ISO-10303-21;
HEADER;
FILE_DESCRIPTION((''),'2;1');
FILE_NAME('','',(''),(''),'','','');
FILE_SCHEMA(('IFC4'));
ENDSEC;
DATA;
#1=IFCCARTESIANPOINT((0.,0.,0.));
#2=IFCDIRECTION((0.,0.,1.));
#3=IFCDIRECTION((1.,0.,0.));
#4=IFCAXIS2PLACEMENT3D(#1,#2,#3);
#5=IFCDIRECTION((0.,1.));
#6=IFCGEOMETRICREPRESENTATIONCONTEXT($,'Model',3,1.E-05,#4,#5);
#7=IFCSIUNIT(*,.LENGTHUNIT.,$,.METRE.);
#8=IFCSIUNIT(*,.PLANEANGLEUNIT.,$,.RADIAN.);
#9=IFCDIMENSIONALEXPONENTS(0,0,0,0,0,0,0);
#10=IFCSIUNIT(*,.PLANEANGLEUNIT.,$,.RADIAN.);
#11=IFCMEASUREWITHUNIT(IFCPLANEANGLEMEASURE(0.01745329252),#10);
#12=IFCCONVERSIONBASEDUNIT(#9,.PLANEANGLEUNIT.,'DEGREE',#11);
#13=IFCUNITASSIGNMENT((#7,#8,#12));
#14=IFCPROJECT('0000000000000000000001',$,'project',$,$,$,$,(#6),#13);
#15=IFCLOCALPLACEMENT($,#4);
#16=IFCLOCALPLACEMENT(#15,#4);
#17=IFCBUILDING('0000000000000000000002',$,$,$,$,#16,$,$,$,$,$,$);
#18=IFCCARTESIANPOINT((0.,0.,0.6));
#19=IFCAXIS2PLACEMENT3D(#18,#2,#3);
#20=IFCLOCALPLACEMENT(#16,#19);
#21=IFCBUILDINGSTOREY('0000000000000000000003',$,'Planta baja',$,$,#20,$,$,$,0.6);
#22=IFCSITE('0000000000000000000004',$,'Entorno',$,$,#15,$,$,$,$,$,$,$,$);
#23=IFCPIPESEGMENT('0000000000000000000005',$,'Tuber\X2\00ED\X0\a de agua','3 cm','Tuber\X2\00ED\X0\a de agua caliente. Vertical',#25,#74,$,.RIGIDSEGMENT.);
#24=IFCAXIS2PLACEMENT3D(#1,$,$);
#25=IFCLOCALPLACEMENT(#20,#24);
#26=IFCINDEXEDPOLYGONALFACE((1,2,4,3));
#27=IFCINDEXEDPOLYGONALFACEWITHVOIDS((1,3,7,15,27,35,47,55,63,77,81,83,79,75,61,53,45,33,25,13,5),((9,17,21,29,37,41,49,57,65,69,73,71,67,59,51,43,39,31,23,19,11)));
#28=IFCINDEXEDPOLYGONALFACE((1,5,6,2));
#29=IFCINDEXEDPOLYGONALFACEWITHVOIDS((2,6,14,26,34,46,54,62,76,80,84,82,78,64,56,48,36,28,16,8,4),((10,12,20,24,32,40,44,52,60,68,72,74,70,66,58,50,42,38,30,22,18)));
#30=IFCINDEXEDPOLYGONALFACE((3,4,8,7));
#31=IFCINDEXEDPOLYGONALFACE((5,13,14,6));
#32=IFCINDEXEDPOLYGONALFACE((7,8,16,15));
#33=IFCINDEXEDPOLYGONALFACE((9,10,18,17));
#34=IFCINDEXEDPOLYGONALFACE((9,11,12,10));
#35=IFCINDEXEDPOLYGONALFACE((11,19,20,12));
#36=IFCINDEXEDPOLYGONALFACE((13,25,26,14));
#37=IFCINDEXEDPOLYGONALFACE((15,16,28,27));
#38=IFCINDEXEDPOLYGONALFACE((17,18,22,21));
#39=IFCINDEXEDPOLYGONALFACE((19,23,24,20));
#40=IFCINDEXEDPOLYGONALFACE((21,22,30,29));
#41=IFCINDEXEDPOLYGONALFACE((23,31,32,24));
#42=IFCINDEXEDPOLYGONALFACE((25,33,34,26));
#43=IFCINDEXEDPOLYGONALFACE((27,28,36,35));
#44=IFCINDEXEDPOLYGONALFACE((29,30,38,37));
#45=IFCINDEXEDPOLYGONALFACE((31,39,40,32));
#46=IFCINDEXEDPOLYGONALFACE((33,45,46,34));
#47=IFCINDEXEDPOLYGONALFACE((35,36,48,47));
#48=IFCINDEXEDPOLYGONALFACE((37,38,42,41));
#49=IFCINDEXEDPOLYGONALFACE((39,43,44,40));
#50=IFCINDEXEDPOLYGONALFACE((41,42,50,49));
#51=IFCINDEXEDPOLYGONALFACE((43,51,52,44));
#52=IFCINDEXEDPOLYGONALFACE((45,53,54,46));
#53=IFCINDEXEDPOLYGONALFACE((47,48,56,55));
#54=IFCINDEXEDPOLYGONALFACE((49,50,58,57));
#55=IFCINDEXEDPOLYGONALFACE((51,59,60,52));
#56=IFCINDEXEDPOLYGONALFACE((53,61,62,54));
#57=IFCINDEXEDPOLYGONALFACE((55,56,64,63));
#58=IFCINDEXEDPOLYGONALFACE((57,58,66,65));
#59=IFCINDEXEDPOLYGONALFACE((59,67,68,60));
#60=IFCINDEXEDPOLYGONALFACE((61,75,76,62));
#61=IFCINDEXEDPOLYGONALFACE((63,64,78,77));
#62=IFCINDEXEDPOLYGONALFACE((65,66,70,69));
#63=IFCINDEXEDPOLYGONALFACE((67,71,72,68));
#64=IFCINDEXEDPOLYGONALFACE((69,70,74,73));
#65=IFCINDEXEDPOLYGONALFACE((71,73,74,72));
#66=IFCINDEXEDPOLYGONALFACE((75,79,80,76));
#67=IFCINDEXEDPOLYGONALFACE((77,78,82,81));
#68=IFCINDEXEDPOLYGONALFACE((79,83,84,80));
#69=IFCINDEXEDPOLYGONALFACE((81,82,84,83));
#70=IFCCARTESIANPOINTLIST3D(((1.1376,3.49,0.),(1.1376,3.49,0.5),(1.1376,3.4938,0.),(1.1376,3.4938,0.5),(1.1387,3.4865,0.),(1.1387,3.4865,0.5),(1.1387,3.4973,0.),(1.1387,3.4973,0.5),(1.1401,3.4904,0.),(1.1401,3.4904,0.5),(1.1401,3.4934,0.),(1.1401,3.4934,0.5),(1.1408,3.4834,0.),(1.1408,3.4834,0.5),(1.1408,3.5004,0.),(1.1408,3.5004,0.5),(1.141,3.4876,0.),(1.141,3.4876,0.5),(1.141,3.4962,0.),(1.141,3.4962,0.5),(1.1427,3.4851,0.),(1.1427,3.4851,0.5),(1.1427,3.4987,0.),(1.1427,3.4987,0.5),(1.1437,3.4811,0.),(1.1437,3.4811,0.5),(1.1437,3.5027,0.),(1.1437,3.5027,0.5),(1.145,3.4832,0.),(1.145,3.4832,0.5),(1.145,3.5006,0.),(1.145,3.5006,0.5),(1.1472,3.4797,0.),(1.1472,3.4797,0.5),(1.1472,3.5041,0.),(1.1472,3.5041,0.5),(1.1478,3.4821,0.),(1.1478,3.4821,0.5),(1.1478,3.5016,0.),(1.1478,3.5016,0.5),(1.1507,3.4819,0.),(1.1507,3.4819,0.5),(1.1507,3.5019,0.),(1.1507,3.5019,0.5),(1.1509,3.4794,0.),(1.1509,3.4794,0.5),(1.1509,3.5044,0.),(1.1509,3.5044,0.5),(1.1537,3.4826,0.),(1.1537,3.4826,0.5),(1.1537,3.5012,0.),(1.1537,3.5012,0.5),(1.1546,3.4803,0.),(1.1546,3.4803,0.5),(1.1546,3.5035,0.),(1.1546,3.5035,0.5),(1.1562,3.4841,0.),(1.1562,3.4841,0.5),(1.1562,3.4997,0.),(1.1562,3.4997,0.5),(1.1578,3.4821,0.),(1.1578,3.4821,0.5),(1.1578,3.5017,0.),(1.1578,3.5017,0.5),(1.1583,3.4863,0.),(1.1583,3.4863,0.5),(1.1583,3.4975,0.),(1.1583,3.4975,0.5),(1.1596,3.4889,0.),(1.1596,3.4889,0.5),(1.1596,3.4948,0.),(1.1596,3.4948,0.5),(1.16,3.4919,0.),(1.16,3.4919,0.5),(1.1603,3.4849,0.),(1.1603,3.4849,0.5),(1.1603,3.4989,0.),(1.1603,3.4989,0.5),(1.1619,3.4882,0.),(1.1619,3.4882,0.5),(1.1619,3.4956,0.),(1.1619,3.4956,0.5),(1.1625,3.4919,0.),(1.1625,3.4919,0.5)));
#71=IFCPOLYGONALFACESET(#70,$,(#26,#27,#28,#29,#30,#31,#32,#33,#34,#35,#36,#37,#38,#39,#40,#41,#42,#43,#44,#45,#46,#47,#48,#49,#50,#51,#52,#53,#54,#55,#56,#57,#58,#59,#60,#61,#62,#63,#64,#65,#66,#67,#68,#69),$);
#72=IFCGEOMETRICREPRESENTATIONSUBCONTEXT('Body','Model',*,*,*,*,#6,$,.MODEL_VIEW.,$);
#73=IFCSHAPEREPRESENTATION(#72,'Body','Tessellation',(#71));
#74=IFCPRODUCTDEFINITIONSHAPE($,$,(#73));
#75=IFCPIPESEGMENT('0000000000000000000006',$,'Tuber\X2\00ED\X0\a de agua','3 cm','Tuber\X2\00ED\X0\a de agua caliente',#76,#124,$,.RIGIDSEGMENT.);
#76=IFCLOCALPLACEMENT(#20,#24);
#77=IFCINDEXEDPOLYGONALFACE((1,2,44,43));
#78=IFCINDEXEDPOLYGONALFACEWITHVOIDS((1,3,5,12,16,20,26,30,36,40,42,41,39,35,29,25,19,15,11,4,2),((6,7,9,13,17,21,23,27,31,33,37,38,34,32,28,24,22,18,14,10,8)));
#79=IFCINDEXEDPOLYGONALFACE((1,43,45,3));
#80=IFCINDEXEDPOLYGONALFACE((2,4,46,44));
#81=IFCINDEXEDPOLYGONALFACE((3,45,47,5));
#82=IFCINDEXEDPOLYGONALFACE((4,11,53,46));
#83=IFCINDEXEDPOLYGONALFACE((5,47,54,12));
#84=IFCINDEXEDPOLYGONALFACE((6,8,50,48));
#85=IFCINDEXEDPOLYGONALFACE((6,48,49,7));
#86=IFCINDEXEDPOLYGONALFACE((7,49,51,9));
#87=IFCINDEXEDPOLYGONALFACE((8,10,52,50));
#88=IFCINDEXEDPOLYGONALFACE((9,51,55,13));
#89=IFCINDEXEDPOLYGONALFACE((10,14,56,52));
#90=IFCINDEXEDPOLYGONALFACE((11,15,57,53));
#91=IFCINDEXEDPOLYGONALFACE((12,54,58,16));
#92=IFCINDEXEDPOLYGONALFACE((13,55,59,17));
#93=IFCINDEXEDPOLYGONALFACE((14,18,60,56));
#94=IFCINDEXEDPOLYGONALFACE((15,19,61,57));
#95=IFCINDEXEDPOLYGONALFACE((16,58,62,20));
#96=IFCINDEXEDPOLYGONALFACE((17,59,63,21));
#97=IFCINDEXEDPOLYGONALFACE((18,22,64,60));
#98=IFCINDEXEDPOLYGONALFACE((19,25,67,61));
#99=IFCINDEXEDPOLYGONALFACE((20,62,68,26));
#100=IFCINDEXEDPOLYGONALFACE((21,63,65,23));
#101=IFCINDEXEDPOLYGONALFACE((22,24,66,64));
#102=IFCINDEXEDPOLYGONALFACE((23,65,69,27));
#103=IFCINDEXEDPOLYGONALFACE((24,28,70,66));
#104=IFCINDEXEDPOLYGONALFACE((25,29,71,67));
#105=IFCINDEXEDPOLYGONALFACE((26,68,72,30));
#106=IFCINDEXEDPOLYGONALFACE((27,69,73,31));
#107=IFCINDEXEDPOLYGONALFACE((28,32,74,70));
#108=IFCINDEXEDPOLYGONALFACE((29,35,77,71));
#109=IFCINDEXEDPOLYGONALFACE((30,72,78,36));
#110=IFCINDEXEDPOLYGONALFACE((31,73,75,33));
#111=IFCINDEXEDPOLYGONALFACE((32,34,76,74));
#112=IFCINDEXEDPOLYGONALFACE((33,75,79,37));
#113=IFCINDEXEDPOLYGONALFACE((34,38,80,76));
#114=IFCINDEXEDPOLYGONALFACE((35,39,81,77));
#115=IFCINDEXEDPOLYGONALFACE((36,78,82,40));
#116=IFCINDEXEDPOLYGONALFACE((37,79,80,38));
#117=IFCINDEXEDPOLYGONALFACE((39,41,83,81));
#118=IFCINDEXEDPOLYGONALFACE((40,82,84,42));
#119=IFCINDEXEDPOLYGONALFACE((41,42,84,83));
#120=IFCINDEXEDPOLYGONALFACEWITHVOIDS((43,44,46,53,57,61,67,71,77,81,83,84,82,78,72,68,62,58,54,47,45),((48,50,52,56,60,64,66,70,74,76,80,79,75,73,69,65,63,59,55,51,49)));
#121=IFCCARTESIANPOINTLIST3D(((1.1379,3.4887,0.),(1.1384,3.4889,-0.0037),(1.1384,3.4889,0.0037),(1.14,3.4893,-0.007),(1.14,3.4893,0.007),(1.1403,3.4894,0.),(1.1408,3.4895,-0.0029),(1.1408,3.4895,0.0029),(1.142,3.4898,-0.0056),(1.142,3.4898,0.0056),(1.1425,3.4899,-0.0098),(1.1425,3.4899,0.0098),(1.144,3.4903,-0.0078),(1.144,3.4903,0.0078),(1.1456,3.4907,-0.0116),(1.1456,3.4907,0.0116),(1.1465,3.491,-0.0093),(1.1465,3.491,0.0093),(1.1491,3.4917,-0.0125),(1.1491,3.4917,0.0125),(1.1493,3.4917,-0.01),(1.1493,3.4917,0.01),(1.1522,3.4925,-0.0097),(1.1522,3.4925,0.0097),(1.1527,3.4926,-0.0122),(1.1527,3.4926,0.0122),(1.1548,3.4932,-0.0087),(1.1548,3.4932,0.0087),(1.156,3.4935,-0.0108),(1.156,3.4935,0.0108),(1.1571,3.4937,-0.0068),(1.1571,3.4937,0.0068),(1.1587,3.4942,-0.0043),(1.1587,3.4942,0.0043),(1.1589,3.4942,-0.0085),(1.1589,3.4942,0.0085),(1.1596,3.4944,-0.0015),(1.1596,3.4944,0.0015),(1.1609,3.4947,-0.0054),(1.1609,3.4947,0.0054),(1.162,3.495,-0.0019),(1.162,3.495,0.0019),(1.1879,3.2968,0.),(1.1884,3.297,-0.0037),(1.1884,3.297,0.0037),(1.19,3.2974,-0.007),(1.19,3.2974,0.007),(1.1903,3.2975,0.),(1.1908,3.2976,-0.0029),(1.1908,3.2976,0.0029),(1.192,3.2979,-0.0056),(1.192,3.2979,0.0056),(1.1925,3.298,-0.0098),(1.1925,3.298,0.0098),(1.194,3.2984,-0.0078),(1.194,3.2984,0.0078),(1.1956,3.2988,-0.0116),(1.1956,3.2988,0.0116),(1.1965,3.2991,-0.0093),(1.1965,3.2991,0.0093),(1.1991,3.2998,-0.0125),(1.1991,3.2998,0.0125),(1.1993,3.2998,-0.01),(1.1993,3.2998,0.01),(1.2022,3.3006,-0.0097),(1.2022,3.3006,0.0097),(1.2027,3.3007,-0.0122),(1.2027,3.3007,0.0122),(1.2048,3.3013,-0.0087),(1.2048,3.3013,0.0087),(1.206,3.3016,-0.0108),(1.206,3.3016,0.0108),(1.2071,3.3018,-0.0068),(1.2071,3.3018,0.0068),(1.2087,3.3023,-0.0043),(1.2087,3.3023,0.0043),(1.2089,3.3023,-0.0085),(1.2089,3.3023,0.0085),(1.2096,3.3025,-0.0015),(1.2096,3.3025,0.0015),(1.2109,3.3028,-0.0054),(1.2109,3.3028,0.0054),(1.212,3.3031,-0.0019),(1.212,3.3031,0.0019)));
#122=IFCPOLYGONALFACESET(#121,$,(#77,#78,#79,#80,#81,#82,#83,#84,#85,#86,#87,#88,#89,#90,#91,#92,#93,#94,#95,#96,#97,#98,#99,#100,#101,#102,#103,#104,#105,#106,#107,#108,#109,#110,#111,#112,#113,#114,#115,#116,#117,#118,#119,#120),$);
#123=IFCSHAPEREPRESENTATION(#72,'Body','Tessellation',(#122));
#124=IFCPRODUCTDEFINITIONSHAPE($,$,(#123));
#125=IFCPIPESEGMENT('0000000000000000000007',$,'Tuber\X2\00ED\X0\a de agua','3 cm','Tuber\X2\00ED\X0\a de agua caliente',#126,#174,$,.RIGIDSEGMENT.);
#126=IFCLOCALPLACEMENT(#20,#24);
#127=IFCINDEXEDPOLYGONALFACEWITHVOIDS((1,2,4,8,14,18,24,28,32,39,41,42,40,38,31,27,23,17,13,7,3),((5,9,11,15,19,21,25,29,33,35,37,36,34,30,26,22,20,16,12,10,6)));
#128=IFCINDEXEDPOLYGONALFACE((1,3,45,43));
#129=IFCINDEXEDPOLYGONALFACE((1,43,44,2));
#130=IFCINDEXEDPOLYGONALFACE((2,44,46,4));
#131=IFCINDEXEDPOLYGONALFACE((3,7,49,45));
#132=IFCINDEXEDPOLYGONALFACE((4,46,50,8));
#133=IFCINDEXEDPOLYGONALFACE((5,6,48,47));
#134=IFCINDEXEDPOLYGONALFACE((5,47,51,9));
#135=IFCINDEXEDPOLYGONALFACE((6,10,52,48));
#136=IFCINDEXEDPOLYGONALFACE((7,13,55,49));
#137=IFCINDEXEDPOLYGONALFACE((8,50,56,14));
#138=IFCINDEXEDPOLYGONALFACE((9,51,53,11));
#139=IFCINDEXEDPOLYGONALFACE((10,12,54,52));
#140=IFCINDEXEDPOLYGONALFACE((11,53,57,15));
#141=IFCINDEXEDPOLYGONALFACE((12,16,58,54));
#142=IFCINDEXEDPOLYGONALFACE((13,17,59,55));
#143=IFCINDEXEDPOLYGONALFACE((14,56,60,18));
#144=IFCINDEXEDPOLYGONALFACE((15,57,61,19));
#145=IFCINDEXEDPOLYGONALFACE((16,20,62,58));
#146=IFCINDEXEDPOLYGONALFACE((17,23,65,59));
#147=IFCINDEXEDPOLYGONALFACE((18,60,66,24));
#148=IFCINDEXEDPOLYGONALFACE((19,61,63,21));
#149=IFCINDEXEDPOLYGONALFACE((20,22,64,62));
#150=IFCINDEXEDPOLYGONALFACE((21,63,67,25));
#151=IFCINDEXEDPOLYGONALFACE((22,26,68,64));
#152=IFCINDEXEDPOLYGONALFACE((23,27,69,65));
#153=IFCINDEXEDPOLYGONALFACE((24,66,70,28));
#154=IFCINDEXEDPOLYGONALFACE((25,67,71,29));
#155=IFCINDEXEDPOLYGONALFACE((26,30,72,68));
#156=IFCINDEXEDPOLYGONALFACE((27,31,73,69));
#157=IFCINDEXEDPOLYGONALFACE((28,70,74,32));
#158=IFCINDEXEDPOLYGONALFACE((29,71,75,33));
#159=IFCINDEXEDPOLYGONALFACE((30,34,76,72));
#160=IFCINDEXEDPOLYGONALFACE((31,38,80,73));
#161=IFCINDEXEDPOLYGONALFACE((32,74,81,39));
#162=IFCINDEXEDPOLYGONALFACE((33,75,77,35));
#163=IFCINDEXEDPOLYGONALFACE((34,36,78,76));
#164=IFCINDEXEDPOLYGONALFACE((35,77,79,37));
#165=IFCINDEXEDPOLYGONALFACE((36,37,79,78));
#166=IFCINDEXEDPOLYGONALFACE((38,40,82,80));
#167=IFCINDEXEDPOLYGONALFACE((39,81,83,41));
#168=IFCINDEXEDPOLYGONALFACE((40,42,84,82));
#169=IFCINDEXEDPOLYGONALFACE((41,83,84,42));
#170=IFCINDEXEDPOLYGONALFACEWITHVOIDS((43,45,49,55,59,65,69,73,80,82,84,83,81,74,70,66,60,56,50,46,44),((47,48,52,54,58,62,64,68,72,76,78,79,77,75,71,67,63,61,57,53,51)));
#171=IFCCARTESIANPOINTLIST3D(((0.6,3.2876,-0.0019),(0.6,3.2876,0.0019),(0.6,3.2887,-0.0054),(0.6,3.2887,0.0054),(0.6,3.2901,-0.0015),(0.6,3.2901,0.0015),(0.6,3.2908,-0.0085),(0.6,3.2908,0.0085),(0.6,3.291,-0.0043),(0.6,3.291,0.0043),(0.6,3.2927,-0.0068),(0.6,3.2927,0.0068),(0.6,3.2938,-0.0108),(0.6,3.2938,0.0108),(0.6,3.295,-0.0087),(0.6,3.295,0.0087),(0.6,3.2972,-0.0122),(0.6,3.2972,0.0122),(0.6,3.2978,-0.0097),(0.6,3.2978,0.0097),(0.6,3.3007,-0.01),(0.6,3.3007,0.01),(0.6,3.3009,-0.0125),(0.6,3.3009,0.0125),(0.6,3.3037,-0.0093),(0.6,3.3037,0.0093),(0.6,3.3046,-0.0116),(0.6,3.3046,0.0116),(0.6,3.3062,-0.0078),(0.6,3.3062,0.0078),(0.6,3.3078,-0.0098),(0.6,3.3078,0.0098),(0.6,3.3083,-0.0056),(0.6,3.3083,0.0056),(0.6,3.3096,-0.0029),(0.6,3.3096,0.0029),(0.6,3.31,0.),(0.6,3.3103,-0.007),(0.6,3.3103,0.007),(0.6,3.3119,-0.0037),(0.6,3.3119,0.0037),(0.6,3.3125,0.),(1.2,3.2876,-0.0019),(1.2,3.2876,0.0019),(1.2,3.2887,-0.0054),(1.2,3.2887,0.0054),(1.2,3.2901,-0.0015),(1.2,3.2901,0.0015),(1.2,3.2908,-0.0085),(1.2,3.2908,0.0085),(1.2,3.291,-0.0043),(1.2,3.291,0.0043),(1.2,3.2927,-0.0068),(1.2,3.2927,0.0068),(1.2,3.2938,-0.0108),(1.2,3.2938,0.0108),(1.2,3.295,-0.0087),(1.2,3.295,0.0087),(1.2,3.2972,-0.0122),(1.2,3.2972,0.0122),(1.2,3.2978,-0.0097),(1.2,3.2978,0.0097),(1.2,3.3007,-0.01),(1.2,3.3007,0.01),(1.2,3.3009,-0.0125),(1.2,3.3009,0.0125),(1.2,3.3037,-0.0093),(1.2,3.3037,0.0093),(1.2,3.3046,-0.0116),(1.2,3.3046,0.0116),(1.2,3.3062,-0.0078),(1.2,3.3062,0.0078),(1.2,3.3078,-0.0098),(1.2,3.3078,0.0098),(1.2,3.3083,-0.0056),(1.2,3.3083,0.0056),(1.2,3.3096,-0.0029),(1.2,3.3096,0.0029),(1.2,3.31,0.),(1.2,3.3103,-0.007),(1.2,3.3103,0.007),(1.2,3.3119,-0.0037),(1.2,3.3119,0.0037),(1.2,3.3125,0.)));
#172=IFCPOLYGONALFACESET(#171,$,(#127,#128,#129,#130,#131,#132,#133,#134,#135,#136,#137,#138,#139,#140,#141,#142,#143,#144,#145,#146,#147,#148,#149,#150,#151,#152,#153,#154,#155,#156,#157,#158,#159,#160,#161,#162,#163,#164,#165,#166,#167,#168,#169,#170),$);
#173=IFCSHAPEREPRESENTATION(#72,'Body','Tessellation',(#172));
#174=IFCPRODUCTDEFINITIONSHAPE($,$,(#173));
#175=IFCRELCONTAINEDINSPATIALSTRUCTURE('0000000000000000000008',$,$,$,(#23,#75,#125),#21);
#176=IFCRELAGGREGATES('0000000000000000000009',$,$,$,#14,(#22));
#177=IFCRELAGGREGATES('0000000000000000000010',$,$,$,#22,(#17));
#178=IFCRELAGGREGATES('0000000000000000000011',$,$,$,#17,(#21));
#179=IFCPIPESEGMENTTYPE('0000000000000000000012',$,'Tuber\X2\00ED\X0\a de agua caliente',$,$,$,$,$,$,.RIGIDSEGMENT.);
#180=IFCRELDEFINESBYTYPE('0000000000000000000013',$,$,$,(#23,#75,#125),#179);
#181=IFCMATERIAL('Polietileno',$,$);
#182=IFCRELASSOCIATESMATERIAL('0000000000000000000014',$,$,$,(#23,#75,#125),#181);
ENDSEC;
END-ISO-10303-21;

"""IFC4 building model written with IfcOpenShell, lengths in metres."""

from ifc_helpers import new_model, entity, si_unit, converted_unit, direction, frame, origin_with_axes, origin_2d_with_axis, place, context, subcontext, project, spatial, hollow_circle, extrude, material, type_object, element, save


model = new_model("IFC4")

# Units and contexts
model_context = context("Model", 3, precision=1e-05, world=origin_with_axes(), true_north=direction((0.0, 1.0)))
body_context = subcontext(model_context, "Body", "Model", "MODEL_VIEW")
ifc_project = project(units=[si_unit("LENGTHUNIT", "METRE"), si_unit("PLANEANGLEUNIT", "RADIAN"), converted_unit("PLANEANGLEUNIT", "DEGREE", entity("IfcPlaneAngleMeasure", 0.01745329252), si_unit("PLANEANGLEUNIT", "RADIAN"), dimensions=[0, 0, 0, 0, 0, 0, 0])], contexts=[model_context])

# Site, building, storey
site_placement = place(None, origin_with_axes())
site = spatial("IfcSite", under=ifc_project, at=site_placement, Name="Entorno")
building_placement = place(site_placement, origin_with_axes())
building = spatial("IfcBuilding", under=site, at=building_placement)
storey_placement = place(building_placement, frame((0.0, 0.0, 0.6), z_axis=(0.0, 0.0, 1.0), x_axis=(1.0, 0.0, 0.0)))
storey = spatial("IfcBuildingStorey", under=building, at=storey_placement, Name="Planta baja", Elevation=0.6)

# Shared definitions
ifc_material_1 = material(Name="Polietileno")

# Pipe segments
pipe_segment_type_1 = type_object("IfcPipeSegmentType", Name="Tubería de agua caliente", PredefinedType="RIGIDSEGMENT")
pipe_segment_1_placement = place(storey_placement, frame((1.15, 3.4919, 0.0), z_axis=(0.0, 0.0, 1.0), x_axis=(1.0, 0.0, 0.0)))
element("IfcPipeSegment", 1, at=pipe_segment_1_placement, inside=storey, type_object=pipe_segment_type_1, material=ifc_material_1, Name="Tubería de agua", Description="3 cm", ObjectType="Tubería de agua caliente. Vertical", PredefinedType="RIGIDSEGMENT", context=body_context, shape_type="SweptSolid", body=[
    extrude(hollow_circle(Radius=0.0125, WallThickness=0.0025, at=origin_2d_with_axis()), origin_with_axes(), (0.0, 0.0, 1.0), 0.5),
])
pipe_segment_2_placement = place(storey_placement, frame((1.2, 3.3, 0.0), z_axis=(-0.252144, 0.96769, 0.0), x_axis=(-0.96769, -0.252144, 0.0)))
element("IfcPipeSegment", 2, at=pipe_segment_2_placement, inside=storey, type_object=pipe_segment_type_1, material=ifc_material_1, Name="Tubería de agua", Description="3 cm", ObjectType="Tubería de agua caliente", PredefinedType="RIGIDSEGMENT", context=body_context, shape_type="SweptSolid", body=[
    extrude(hollow_circle(Radius=0.0125, WallThickness=0.0025, at=origin_2d_with_axis()), origin_with_axes(), (0.0, 0.0, 1.0), 0.1983),
])
pipe_segment_3_placement = place(storey_placement, frame((0.6, 3.3, 0.0), z_axis=(1.0, 0.0, 0.0), x_axis=(0.0, 1.0, 0.0)))
element("IfcPipeSegment", 3, at=pipe_segment_3_placement, inside=storey, type_object=pipe_segment_type_1, material=ifc_material_1, Name="Tubería de agua", Description="3 cm", ObjectType="Tubería de agua caliente", PredefinedType="RIGIDSEGMENT", context=body_context, shape_type="SweptSolid", body=[
    extrude(hollow_circle(Radius=0.0125, WallThickness=0.0025, at=origin_2d_with_axis()), origin_with_axes(), (0.0, 0.0, 1.0), 0.6),
])

save(model, "model.ifc")
